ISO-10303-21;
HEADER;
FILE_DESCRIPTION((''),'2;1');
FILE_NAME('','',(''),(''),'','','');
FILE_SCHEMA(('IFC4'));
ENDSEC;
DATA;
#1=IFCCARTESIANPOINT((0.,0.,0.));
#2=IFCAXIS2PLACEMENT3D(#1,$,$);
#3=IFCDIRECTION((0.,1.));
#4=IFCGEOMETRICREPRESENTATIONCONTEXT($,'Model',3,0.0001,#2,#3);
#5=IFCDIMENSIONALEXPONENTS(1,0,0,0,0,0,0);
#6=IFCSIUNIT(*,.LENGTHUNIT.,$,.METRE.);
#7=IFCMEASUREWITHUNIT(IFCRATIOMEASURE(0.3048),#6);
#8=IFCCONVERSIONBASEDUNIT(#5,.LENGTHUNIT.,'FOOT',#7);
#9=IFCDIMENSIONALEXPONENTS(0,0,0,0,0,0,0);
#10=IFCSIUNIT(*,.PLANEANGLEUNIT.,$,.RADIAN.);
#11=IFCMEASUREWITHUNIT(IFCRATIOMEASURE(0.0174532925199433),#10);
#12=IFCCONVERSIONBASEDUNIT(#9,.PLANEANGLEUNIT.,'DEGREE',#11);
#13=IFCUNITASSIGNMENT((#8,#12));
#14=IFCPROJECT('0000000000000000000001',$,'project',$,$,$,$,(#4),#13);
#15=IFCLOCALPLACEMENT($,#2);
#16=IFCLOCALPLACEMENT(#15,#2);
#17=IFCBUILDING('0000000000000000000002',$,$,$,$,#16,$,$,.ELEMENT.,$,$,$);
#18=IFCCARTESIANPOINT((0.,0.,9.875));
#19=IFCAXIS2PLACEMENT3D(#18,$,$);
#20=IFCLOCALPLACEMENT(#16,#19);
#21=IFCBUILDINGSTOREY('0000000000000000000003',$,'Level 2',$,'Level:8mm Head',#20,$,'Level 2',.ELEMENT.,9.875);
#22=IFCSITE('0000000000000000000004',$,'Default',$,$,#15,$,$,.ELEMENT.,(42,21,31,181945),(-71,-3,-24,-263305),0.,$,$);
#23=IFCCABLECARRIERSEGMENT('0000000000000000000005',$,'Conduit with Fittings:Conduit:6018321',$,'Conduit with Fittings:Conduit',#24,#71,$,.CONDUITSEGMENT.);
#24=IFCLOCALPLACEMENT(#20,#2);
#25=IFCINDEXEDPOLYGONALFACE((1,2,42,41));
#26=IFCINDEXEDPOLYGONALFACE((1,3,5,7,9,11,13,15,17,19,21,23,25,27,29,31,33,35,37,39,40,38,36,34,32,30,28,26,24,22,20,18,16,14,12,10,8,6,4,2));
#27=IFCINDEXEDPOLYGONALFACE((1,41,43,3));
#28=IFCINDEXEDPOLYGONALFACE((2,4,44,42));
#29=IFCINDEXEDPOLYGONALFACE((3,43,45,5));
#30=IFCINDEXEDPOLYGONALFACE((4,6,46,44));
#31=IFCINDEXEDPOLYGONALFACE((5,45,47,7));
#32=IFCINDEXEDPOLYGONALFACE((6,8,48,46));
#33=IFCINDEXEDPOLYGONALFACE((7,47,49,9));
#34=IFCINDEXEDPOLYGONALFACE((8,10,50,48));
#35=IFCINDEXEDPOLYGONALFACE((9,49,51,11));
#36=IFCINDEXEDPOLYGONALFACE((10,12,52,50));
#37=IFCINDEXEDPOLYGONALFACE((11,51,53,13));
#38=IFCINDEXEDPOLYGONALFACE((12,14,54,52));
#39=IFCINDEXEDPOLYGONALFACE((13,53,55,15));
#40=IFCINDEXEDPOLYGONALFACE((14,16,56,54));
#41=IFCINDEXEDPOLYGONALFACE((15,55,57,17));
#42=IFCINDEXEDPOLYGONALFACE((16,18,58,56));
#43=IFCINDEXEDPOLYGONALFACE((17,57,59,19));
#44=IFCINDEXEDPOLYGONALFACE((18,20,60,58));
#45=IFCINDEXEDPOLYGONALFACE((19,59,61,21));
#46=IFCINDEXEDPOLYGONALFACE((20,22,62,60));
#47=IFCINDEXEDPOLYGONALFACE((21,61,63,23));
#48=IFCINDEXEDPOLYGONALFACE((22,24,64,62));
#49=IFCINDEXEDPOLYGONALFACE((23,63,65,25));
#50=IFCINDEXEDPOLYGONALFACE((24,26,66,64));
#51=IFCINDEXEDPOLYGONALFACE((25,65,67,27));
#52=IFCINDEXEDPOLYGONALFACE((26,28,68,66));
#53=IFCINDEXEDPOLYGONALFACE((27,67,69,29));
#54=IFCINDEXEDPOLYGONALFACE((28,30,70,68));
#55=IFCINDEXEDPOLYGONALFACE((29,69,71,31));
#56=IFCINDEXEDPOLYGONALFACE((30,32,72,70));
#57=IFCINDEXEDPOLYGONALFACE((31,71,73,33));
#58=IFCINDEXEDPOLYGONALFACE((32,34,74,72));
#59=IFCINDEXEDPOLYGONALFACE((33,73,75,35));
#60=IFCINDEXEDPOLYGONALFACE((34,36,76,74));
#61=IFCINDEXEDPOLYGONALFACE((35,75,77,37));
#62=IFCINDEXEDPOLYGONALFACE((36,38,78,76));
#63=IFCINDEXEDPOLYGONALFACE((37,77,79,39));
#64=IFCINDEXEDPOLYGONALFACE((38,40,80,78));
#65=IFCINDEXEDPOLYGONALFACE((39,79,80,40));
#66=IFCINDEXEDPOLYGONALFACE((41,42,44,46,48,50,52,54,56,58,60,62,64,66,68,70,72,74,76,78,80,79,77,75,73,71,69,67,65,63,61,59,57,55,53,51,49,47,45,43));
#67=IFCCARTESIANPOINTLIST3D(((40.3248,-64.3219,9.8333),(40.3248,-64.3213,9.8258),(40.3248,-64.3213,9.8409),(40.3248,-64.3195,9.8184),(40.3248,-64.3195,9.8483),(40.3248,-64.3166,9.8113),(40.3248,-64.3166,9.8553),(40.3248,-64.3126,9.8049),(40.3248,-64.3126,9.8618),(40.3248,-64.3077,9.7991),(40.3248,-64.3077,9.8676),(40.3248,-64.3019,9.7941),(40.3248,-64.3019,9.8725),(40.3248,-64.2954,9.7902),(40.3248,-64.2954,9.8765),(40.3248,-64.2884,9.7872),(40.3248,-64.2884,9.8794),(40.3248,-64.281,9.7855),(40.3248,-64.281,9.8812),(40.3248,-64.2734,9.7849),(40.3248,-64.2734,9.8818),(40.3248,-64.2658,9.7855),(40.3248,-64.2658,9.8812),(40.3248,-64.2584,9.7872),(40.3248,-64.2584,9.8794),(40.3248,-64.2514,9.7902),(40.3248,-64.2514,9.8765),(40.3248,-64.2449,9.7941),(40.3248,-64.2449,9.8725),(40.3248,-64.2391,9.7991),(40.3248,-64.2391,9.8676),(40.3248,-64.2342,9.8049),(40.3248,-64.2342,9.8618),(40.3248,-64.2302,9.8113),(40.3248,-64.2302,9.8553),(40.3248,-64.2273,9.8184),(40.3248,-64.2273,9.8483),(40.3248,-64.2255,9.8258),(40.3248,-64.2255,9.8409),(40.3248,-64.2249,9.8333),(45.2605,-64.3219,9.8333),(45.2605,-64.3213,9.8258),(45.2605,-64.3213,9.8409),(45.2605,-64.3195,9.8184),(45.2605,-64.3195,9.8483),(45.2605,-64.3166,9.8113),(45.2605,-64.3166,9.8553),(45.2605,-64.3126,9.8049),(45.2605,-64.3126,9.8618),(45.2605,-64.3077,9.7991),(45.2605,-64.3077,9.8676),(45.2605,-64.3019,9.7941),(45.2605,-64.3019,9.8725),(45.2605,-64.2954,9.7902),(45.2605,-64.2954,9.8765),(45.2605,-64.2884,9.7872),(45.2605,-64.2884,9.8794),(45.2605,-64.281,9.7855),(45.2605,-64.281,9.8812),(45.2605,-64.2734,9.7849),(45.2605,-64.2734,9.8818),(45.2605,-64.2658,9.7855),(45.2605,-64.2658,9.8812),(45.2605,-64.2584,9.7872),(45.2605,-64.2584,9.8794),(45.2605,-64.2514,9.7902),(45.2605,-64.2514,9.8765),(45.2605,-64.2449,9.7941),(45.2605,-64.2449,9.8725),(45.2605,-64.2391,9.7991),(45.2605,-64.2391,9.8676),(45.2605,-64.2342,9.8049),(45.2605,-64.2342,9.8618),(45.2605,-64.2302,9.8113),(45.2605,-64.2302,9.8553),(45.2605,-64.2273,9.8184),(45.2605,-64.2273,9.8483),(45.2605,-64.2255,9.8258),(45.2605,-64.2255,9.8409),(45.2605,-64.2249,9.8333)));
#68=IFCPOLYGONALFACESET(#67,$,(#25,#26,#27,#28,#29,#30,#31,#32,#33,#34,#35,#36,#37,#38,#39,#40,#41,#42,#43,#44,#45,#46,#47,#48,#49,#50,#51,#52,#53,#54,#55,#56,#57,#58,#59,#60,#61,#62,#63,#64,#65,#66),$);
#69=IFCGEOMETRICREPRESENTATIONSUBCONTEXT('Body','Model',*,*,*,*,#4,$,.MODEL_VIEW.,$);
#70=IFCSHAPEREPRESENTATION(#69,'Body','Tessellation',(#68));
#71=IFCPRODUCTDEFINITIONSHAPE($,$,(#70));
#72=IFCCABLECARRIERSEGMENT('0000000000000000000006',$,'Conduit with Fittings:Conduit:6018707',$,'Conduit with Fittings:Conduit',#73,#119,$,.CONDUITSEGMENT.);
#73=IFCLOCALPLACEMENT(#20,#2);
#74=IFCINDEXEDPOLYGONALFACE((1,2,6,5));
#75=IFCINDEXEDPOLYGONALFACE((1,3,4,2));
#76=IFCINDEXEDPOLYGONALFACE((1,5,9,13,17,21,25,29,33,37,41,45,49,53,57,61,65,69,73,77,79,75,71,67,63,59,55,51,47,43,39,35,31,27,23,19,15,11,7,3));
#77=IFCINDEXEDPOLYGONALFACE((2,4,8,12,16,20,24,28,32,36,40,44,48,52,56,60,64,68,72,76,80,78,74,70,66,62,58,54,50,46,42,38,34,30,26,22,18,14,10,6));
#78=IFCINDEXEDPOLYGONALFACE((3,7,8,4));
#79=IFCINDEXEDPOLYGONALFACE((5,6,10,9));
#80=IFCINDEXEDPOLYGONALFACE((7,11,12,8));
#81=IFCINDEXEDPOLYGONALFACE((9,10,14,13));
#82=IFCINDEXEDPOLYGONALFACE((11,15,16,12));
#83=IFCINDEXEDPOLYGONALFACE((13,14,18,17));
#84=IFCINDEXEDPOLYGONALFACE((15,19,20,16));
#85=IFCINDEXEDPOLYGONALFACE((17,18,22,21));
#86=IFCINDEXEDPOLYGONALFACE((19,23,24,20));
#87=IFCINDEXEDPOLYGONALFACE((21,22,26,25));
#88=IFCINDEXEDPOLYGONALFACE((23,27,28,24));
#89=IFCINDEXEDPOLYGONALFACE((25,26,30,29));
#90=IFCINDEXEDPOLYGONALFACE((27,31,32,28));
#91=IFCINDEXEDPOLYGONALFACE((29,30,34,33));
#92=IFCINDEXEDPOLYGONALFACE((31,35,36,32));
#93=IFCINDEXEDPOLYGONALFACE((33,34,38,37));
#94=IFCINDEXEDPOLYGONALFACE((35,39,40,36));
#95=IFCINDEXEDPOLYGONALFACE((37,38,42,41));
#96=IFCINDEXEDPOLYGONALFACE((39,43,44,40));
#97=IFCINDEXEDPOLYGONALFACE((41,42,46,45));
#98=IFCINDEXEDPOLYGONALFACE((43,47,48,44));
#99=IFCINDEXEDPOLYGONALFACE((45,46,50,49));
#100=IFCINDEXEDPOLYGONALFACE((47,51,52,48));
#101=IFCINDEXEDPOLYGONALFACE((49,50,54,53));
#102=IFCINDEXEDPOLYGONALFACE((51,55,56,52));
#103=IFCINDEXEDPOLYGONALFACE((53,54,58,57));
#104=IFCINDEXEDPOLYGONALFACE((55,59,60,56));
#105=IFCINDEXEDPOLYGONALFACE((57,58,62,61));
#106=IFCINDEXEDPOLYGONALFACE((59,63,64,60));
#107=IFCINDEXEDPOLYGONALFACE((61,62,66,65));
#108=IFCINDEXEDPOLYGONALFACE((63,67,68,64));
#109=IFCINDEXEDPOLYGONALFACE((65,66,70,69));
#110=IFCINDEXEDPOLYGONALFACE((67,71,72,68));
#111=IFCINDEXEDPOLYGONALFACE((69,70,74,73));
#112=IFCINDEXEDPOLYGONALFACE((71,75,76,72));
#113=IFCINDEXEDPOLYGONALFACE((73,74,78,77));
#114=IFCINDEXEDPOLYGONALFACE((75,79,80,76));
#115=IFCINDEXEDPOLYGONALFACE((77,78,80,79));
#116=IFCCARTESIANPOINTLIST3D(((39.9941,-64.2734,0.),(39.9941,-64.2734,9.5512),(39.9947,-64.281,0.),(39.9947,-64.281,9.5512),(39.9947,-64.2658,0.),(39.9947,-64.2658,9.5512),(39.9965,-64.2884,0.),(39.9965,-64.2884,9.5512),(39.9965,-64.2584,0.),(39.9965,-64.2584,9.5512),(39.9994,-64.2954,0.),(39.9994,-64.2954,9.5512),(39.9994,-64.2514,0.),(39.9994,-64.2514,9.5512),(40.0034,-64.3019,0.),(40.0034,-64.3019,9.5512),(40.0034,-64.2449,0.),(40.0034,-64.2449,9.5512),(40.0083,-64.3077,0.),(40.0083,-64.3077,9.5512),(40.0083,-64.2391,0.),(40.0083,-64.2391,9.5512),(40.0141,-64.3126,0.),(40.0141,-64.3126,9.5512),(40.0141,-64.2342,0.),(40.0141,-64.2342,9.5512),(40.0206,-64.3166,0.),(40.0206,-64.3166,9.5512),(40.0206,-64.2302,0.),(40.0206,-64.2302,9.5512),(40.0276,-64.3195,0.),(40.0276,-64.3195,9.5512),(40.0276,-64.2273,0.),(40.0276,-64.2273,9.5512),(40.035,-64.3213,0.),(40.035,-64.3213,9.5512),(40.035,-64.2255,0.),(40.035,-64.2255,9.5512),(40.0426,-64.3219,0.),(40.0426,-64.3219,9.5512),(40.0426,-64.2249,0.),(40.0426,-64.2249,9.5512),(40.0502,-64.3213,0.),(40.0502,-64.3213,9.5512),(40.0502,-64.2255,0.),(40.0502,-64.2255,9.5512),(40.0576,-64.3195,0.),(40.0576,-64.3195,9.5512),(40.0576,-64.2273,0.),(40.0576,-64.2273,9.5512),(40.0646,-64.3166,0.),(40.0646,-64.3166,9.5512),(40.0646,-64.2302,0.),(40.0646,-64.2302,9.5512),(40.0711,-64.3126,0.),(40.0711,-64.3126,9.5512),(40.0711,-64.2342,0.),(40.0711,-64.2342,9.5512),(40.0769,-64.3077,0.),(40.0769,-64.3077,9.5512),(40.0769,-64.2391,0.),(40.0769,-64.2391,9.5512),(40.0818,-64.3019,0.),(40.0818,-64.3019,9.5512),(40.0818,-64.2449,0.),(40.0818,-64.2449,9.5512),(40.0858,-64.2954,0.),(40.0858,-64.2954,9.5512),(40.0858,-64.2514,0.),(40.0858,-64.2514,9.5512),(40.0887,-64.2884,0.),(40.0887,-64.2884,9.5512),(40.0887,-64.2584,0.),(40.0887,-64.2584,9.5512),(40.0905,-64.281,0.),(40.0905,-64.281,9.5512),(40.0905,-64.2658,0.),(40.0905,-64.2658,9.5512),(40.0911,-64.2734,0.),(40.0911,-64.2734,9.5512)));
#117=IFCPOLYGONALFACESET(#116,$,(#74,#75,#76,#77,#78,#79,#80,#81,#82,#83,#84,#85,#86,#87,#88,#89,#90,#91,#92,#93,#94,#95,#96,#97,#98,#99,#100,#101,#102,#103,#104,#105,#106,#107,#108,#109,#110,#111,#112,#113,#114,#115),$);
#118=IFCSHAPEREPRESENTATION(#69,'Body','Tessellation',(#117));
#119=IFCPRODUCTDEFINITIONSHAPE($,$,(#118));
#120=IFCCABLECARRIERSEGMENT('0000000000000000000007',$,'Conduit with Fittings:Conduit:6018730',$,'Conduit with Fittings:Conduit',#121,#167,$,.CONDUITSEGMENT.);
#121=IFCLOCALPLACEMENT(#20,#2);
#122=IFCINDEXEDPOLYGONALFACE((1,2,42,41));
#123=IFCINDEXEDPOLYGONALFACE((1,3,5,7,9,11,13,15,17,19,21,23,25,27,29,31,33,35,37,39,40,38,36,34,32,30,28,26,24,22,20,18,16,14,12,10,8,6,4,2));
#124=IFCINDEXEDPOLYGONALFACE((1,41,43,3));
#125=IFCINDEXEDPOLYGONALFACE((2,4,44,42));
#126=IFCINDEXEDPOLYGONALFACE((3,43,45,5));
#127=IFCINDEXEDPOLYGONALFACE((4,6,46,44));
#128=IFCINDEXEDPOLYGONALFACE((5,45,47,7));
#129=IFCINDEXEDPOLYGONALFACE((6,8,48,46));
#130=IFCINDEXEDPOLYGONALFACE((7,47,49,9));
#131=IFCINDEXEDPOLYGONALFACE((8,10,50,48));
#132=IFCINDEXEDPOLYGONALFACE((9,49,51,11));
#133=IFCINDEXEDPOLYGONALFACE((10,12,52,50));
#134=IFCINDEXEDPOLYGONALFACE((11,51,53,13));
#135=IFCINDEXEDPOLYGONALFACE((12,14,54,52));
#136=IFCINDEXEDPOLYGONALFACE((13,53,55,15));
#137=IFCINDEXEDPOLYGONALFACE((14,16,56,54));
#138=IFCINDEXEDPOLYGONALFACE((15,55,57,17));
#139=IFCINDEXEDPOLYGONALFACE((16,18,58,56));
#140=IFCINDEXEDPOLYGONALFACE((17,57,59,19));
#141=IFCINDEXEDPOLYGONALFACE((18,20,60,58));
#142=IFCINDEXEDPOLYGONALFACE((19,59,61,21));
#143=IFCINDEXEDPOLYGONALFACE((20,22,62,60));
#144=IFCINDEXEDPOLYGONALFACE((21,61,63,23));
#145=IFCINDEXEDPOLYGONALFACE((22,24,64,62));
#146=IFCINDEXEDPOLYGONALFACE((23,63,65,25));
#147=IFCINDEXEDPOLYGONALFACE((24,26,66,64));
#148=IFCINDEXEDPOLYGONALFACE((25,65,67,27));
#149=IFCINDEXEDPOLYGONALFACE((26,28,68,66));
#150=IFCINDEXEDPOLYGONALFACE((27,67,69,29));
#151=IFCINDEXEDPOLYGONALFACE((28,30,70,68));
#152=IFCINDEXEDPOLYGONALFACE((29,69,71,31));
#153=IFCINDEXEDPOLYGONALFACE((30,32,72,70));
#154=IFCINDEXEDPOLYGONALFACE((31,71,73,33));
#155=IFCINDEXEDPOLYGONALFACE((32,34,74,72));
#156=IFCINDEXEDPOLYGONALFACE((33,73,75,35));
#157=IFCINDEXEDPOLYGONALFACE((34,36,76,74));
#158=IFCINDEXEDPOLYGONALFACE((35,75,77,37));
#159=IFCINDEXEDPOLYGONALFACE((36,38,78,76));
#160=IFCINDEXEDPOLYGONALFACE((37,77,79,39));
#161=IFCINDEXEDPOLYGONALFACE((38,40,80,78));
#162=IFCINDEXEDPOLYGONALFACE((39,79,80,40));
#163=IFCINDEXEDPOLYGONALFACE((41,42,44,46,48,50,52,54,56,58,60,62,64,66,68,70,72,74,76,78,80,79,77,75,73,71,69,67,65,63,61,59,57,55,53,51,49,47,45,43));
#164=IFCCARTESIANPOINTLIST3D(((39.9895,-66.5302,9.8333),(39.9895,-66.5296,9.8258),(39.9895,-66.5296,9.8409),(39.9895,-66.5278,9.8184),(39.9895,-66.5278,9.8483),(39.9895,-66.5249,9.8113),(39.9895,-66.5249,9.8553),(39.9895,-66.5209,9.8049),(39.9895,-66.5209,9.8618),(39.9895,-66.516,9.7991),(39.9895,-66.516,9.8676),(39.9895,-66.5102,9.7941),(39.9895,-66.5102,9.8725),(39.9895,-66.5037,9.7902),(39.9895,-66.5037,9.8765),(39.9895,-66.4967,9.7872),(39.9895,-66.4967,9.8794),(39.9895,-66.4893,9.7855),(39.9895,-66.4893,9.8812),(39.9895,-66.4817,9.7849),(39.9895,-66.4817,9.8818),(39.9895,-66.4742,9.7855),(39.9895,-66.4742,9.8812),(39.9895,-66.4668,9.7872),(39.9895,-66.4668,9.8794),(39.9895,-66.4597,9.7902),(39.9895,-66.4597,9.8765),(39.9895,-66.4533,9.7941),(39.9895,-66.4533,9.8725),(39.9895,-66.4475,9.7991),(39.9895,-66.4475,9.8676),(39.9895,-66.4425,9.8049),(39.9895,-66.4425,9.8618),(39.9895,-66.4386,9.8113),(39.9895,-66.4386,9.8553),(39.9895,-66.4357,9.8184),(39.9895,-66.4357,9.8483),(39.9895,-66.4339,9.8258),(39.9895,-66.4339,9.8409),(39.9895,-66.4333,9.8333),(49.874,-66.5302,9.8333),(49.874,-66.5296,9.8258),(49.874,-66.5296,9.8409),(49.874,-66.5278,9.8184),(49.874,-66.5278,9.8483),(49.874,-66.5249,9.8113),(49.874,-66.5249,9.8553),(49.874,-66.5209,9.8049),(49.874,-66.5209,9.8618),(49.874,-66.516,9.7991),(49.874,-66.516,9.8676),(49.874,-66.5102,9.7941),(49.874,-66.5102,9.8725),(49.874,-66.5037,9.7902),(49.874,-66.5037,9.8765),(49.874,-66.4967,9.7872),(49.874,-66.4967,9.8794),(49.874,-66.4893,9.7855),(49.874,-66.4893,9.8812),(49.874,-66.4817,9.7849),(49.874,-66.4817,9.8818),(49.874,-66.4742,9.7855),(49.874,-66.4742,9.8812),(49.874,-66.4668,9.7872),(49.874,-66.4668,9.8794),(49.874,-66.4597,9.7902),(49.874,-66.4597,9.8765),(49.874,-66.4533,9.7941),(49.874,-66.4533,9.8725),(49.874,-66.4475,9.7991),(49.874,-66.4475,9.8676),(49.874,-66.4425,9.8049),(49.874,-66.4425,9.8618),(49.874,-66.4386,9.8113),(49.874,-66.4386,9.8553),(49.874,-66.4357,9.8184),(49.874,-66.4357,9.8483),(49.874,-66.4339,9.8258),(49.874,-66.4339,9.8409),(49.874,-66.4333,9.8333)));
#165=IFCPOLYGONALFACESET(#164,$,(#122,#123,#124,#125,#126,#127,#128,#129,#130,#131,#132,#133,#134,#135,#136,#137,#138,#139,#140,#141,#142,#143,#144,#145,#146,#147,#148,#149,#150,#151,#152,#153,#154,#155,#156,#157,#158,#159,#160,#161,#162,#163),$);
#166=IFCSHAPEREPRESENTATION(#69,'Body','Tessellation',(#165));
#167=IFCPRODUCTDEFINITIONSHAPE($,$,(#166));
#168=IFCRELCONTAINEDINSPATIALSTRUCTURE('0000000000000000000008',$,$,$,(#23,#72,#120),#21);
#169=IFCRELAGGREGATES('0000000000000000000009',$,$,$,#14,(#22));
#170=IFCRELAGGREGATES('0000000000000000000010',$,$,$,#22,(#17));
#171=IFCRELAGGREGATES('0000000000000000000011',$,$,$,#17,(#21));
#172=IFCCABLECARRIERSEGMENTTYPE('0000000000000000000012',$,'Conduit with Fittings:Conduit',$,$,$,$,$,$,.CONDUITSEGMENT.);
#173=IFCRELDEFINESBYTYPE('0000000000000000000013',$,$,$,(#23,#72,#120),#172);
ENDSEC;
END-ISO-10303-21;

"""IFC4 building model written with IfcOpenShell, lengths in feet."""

from ifc_helpers import new_model, entity, si_unit, converted_unit, direction, frame, origin, place, context, subcontext, project, spatial, indexed_curve, outline, extrude, type_object, element, save


model = new_model("IFC4")

# Units and contexts
model_context = context("Model", 3, precision=0.0001, world=origin(), true_north=direction((0.0, 1.0)))
body_context = subcontext(model_context, "Body", "Model", "MODEL_VIEW")
ifc_project = project(units=[converted_unit("LENGTHUNIT", "FOOT", entity("IfcRatioMeasure", 0.3048), si_unit("LENGTHUNIT", "METRE"), dimensions=[1, 0, 0, 0, 0, 0, 0]), converted_unit("PLANEANGLEUNIT", "DEGREE", entity("IfcRatioMeasure", 0.0174532925199433), si_unit("PLANEANGLEUNIT", "RADIAN"), dimensions=[0, 0, 0, 0, 0, 0, 0])], contexts=[model_context])

# Site, building, storey
site_placement = place(None, origin())
site = spatial("IfcSite", under=ifc_project, at=site_placement, Name="Default", CompositionType="ELEMENT", RefLatitude=(42, 21, 31, 181945), RefLongitude=(-71, -3, -24, -263305), RefElevation=0.0)
building_placement = place(site_placement, origin())
building = spatial("IfcBuilding", under=site, at=building_placement, CompositionType="ELEMENT")
storey_placement = place(building_placement, frame((0.0, 0.0, 9.875)))
storey = spatial("IfcBuildingStorey", under=building, at=storey_placement, Name="Level 2", ObjectType="Level:8mm Head", LongName="Level 2", CompositionType="ELEMENT", Elevation=9.875)

# Cable carrier segments
cable_carrier_segment_type = type_object("IfcCableCarrierSegmentType", Name="Conduit with Fittings:Conduit", PredefinedType="CONDUITSEGMENT")
cable_carrier_segment_1_placement = place(storey_placement, origin())
element("IfcCableCarrierSegment", 1, at=cable_carrier_segment_1_placement, inside=storey, type_object=cable_carrier_segment_type, Name="Conduit with Fittings:Conduit:6018321", ObjectType="Conduit with Fittings:Conduit", PredefinedType="CONDUITSEGMENT", context=body_context, shape_type="SweptSolid", body=[
    extrude(outline(indexed_curve([(0.0485, 0.0), (0.0479, 0.0076), (0.0461, 0.015), (0.0432, 0.022), (0.0392, 0.0285), (0.0343, 0.0343), (0.0285, 0.0392), (0.022, 0.0432), (0.015, 0.0461), (0.0076, 0.0479), (0.0, 0.0485), (-0.0076, 0.0479), (-0.015, 0.0461), (-0.022, 0.0432), (-0.0285, 0.0392), (-0.0343, 0.0343), (-0.0392, 0.0285), (-0.0432, 0.022), (-0.0461, 0.015), (-0.0479, 0.0076), (-0.0485, 0.0), (-0.0479, -0.0076), (-0.0461, -0.015), (-0.0432, -0.022), (-0.0392, -0.0285), (-0.0343, -0.0343), (-0.0285, -0.0392), (-0.022, -0.0432), (-0.015, -0.0461), (-0.0076, -0.0479), (0.0, -0.0485), (0.0076, -0.0479), (0.015, -0.0461), (0.022, -0.0432), (0.0285, -0.0392), (0.0343, -0.0343), (0.0392, -0.0285), (0.0432, -0.022), (0.0461, -0.015), (0.0479, -0.0076), (0.0485, 0.0)], self_intersect=False)), frame((40.3248, -64.2734, 9.8333), z_axis=(1.0, 0.0, 0.0), x_axis=(0.0, 1.0, 0.0)), (0.0, 0.0, 1.0), 4.9357),
])
cable_carrier_segment_2_placement = place(storey_placement, origin())
element("IfcCableCarrierSegment", 2, at=cable_carrier_segment_2_placement, inside=storey, type_object=cable_carrier_segment_type, Name="Conduit with Fittings:Conduit:6018707", ObjectType="Conduit with Fittings:Conduit", PredefinedType="CONDUITSEGMENT", context=body_context, shape_type="SweptSolid", body=[
    extrude(outline(indexed_curve([(0.0485, 0.0), (0.0479, 0.0076), (0.0461, 0.015), (0.0432, 0.022), (0.0392, 0.0285), (0.0343, 0.0343), (0.0285, 0.0392), (0.022, 0.0432), (0.015, 0.0461), (0.0076, 0.0479), (0.0, 0.0485), (-0.0076, 0.0479), (-0.015, 0.0461), (-0.022, 0.0432), (-0.0285, 0.0392), (-0.0343, 0.0343), (-0.0392, 0.0285), (-0.0432, 0.022), (-0.0461, 0.015), (-0.0479, 0.0076), (-0.0485, 0.0), (-0.0479, -0.0076), (-0.0461, -0.015), (-0.0432, -0.022), (-0.0392, -0.0285), (-0.0343, -0.0343), (-0.0285, -0.0392), (-0.022, -0.0432), (-0.015, -0.0461), (-0.0076, -0.0479), (0.0, -0.0485), (0.0076, -0.0479), (0.015, -0.0461), (0.022, -0.0432), (0.0285, -0.0392), (0.0343, -0.0343), (0.0392, -0.0285), (0.0432, -0.022), (0.0461, -0.015), (0.0479, -0.0076), (0.0485, 0.0)], self_intersect=False)), frame((40.0426, -64.2734, 0.0)), (0.0, 0.0, 1.0), 9.5512),
])
cable_carrier_segment_3_placement = place(storey_placement, origin())
element("IfcCableCarrierSegment", 3, at=cable_carrier_segment_3_placement, inside=storey, type_object=cable_carrier_segment_type, Name="Conduit with Fittings:Conduit:6018730", ObjectType="Conduit with Fittings:Conduit", PredefinedType="CONDUITSEGMENT", context=body_context, shape_type="SweptSolid", body=[
    extrude(outline(indexed_curve([(0.0485, 0.0), (0.0479, 0.0076), (0.0461, 0.015), (0.0432, 0.022), (0.0392, 0.0285), (0.0343, 0.0343), (0.0285, 0.0392), (0.022, 0.0432), (0.015, 0.0461), (0.0076, 0.0479), (0.0, 0.0485), (-0.0076, 0.0479), (-0.015, 0.0461), (-0.022, 0.0432), (-0.0285, 0.0392), (-0.0343, 0.0343), (-0.0392, 0.0285), (-0.0432, 0.022), (-0.0461, 0.015), (-0.0479, 0.0076), (-0.0485, 0.0), (-0.0479, -0.0076), (-0.0461, -0.015), (-0.0432, -0.022), (-0.0392, -0.0285), (-0.0343, -0.0343), (-0.0285, -0.0392), (-0.022, -0.0432), (-0.015, -0.0461), (-0.0076, -0.0479), (0.0, -0.0485), (0.0076, -0.0479), (0.015, -0.0461), (0.022, -0.0432), (0.0285, -0.0392), (0.0343, -0.0343), (0.0392, -0.0285), (0.0432, -0.022), (0.0461, -0.015), (0.0479, -0.0076), (0.0485, 0.0)], self_intersect=False)), frame((39.9895, -66.4817, 9.8333), z_axis=(1.0, 0.0, 0.0), x_axis=(0.0, 1.0, 0.0)), (0.0, 0.0, 1.0), 9.8845),
])

save(model, "model.ifc")
